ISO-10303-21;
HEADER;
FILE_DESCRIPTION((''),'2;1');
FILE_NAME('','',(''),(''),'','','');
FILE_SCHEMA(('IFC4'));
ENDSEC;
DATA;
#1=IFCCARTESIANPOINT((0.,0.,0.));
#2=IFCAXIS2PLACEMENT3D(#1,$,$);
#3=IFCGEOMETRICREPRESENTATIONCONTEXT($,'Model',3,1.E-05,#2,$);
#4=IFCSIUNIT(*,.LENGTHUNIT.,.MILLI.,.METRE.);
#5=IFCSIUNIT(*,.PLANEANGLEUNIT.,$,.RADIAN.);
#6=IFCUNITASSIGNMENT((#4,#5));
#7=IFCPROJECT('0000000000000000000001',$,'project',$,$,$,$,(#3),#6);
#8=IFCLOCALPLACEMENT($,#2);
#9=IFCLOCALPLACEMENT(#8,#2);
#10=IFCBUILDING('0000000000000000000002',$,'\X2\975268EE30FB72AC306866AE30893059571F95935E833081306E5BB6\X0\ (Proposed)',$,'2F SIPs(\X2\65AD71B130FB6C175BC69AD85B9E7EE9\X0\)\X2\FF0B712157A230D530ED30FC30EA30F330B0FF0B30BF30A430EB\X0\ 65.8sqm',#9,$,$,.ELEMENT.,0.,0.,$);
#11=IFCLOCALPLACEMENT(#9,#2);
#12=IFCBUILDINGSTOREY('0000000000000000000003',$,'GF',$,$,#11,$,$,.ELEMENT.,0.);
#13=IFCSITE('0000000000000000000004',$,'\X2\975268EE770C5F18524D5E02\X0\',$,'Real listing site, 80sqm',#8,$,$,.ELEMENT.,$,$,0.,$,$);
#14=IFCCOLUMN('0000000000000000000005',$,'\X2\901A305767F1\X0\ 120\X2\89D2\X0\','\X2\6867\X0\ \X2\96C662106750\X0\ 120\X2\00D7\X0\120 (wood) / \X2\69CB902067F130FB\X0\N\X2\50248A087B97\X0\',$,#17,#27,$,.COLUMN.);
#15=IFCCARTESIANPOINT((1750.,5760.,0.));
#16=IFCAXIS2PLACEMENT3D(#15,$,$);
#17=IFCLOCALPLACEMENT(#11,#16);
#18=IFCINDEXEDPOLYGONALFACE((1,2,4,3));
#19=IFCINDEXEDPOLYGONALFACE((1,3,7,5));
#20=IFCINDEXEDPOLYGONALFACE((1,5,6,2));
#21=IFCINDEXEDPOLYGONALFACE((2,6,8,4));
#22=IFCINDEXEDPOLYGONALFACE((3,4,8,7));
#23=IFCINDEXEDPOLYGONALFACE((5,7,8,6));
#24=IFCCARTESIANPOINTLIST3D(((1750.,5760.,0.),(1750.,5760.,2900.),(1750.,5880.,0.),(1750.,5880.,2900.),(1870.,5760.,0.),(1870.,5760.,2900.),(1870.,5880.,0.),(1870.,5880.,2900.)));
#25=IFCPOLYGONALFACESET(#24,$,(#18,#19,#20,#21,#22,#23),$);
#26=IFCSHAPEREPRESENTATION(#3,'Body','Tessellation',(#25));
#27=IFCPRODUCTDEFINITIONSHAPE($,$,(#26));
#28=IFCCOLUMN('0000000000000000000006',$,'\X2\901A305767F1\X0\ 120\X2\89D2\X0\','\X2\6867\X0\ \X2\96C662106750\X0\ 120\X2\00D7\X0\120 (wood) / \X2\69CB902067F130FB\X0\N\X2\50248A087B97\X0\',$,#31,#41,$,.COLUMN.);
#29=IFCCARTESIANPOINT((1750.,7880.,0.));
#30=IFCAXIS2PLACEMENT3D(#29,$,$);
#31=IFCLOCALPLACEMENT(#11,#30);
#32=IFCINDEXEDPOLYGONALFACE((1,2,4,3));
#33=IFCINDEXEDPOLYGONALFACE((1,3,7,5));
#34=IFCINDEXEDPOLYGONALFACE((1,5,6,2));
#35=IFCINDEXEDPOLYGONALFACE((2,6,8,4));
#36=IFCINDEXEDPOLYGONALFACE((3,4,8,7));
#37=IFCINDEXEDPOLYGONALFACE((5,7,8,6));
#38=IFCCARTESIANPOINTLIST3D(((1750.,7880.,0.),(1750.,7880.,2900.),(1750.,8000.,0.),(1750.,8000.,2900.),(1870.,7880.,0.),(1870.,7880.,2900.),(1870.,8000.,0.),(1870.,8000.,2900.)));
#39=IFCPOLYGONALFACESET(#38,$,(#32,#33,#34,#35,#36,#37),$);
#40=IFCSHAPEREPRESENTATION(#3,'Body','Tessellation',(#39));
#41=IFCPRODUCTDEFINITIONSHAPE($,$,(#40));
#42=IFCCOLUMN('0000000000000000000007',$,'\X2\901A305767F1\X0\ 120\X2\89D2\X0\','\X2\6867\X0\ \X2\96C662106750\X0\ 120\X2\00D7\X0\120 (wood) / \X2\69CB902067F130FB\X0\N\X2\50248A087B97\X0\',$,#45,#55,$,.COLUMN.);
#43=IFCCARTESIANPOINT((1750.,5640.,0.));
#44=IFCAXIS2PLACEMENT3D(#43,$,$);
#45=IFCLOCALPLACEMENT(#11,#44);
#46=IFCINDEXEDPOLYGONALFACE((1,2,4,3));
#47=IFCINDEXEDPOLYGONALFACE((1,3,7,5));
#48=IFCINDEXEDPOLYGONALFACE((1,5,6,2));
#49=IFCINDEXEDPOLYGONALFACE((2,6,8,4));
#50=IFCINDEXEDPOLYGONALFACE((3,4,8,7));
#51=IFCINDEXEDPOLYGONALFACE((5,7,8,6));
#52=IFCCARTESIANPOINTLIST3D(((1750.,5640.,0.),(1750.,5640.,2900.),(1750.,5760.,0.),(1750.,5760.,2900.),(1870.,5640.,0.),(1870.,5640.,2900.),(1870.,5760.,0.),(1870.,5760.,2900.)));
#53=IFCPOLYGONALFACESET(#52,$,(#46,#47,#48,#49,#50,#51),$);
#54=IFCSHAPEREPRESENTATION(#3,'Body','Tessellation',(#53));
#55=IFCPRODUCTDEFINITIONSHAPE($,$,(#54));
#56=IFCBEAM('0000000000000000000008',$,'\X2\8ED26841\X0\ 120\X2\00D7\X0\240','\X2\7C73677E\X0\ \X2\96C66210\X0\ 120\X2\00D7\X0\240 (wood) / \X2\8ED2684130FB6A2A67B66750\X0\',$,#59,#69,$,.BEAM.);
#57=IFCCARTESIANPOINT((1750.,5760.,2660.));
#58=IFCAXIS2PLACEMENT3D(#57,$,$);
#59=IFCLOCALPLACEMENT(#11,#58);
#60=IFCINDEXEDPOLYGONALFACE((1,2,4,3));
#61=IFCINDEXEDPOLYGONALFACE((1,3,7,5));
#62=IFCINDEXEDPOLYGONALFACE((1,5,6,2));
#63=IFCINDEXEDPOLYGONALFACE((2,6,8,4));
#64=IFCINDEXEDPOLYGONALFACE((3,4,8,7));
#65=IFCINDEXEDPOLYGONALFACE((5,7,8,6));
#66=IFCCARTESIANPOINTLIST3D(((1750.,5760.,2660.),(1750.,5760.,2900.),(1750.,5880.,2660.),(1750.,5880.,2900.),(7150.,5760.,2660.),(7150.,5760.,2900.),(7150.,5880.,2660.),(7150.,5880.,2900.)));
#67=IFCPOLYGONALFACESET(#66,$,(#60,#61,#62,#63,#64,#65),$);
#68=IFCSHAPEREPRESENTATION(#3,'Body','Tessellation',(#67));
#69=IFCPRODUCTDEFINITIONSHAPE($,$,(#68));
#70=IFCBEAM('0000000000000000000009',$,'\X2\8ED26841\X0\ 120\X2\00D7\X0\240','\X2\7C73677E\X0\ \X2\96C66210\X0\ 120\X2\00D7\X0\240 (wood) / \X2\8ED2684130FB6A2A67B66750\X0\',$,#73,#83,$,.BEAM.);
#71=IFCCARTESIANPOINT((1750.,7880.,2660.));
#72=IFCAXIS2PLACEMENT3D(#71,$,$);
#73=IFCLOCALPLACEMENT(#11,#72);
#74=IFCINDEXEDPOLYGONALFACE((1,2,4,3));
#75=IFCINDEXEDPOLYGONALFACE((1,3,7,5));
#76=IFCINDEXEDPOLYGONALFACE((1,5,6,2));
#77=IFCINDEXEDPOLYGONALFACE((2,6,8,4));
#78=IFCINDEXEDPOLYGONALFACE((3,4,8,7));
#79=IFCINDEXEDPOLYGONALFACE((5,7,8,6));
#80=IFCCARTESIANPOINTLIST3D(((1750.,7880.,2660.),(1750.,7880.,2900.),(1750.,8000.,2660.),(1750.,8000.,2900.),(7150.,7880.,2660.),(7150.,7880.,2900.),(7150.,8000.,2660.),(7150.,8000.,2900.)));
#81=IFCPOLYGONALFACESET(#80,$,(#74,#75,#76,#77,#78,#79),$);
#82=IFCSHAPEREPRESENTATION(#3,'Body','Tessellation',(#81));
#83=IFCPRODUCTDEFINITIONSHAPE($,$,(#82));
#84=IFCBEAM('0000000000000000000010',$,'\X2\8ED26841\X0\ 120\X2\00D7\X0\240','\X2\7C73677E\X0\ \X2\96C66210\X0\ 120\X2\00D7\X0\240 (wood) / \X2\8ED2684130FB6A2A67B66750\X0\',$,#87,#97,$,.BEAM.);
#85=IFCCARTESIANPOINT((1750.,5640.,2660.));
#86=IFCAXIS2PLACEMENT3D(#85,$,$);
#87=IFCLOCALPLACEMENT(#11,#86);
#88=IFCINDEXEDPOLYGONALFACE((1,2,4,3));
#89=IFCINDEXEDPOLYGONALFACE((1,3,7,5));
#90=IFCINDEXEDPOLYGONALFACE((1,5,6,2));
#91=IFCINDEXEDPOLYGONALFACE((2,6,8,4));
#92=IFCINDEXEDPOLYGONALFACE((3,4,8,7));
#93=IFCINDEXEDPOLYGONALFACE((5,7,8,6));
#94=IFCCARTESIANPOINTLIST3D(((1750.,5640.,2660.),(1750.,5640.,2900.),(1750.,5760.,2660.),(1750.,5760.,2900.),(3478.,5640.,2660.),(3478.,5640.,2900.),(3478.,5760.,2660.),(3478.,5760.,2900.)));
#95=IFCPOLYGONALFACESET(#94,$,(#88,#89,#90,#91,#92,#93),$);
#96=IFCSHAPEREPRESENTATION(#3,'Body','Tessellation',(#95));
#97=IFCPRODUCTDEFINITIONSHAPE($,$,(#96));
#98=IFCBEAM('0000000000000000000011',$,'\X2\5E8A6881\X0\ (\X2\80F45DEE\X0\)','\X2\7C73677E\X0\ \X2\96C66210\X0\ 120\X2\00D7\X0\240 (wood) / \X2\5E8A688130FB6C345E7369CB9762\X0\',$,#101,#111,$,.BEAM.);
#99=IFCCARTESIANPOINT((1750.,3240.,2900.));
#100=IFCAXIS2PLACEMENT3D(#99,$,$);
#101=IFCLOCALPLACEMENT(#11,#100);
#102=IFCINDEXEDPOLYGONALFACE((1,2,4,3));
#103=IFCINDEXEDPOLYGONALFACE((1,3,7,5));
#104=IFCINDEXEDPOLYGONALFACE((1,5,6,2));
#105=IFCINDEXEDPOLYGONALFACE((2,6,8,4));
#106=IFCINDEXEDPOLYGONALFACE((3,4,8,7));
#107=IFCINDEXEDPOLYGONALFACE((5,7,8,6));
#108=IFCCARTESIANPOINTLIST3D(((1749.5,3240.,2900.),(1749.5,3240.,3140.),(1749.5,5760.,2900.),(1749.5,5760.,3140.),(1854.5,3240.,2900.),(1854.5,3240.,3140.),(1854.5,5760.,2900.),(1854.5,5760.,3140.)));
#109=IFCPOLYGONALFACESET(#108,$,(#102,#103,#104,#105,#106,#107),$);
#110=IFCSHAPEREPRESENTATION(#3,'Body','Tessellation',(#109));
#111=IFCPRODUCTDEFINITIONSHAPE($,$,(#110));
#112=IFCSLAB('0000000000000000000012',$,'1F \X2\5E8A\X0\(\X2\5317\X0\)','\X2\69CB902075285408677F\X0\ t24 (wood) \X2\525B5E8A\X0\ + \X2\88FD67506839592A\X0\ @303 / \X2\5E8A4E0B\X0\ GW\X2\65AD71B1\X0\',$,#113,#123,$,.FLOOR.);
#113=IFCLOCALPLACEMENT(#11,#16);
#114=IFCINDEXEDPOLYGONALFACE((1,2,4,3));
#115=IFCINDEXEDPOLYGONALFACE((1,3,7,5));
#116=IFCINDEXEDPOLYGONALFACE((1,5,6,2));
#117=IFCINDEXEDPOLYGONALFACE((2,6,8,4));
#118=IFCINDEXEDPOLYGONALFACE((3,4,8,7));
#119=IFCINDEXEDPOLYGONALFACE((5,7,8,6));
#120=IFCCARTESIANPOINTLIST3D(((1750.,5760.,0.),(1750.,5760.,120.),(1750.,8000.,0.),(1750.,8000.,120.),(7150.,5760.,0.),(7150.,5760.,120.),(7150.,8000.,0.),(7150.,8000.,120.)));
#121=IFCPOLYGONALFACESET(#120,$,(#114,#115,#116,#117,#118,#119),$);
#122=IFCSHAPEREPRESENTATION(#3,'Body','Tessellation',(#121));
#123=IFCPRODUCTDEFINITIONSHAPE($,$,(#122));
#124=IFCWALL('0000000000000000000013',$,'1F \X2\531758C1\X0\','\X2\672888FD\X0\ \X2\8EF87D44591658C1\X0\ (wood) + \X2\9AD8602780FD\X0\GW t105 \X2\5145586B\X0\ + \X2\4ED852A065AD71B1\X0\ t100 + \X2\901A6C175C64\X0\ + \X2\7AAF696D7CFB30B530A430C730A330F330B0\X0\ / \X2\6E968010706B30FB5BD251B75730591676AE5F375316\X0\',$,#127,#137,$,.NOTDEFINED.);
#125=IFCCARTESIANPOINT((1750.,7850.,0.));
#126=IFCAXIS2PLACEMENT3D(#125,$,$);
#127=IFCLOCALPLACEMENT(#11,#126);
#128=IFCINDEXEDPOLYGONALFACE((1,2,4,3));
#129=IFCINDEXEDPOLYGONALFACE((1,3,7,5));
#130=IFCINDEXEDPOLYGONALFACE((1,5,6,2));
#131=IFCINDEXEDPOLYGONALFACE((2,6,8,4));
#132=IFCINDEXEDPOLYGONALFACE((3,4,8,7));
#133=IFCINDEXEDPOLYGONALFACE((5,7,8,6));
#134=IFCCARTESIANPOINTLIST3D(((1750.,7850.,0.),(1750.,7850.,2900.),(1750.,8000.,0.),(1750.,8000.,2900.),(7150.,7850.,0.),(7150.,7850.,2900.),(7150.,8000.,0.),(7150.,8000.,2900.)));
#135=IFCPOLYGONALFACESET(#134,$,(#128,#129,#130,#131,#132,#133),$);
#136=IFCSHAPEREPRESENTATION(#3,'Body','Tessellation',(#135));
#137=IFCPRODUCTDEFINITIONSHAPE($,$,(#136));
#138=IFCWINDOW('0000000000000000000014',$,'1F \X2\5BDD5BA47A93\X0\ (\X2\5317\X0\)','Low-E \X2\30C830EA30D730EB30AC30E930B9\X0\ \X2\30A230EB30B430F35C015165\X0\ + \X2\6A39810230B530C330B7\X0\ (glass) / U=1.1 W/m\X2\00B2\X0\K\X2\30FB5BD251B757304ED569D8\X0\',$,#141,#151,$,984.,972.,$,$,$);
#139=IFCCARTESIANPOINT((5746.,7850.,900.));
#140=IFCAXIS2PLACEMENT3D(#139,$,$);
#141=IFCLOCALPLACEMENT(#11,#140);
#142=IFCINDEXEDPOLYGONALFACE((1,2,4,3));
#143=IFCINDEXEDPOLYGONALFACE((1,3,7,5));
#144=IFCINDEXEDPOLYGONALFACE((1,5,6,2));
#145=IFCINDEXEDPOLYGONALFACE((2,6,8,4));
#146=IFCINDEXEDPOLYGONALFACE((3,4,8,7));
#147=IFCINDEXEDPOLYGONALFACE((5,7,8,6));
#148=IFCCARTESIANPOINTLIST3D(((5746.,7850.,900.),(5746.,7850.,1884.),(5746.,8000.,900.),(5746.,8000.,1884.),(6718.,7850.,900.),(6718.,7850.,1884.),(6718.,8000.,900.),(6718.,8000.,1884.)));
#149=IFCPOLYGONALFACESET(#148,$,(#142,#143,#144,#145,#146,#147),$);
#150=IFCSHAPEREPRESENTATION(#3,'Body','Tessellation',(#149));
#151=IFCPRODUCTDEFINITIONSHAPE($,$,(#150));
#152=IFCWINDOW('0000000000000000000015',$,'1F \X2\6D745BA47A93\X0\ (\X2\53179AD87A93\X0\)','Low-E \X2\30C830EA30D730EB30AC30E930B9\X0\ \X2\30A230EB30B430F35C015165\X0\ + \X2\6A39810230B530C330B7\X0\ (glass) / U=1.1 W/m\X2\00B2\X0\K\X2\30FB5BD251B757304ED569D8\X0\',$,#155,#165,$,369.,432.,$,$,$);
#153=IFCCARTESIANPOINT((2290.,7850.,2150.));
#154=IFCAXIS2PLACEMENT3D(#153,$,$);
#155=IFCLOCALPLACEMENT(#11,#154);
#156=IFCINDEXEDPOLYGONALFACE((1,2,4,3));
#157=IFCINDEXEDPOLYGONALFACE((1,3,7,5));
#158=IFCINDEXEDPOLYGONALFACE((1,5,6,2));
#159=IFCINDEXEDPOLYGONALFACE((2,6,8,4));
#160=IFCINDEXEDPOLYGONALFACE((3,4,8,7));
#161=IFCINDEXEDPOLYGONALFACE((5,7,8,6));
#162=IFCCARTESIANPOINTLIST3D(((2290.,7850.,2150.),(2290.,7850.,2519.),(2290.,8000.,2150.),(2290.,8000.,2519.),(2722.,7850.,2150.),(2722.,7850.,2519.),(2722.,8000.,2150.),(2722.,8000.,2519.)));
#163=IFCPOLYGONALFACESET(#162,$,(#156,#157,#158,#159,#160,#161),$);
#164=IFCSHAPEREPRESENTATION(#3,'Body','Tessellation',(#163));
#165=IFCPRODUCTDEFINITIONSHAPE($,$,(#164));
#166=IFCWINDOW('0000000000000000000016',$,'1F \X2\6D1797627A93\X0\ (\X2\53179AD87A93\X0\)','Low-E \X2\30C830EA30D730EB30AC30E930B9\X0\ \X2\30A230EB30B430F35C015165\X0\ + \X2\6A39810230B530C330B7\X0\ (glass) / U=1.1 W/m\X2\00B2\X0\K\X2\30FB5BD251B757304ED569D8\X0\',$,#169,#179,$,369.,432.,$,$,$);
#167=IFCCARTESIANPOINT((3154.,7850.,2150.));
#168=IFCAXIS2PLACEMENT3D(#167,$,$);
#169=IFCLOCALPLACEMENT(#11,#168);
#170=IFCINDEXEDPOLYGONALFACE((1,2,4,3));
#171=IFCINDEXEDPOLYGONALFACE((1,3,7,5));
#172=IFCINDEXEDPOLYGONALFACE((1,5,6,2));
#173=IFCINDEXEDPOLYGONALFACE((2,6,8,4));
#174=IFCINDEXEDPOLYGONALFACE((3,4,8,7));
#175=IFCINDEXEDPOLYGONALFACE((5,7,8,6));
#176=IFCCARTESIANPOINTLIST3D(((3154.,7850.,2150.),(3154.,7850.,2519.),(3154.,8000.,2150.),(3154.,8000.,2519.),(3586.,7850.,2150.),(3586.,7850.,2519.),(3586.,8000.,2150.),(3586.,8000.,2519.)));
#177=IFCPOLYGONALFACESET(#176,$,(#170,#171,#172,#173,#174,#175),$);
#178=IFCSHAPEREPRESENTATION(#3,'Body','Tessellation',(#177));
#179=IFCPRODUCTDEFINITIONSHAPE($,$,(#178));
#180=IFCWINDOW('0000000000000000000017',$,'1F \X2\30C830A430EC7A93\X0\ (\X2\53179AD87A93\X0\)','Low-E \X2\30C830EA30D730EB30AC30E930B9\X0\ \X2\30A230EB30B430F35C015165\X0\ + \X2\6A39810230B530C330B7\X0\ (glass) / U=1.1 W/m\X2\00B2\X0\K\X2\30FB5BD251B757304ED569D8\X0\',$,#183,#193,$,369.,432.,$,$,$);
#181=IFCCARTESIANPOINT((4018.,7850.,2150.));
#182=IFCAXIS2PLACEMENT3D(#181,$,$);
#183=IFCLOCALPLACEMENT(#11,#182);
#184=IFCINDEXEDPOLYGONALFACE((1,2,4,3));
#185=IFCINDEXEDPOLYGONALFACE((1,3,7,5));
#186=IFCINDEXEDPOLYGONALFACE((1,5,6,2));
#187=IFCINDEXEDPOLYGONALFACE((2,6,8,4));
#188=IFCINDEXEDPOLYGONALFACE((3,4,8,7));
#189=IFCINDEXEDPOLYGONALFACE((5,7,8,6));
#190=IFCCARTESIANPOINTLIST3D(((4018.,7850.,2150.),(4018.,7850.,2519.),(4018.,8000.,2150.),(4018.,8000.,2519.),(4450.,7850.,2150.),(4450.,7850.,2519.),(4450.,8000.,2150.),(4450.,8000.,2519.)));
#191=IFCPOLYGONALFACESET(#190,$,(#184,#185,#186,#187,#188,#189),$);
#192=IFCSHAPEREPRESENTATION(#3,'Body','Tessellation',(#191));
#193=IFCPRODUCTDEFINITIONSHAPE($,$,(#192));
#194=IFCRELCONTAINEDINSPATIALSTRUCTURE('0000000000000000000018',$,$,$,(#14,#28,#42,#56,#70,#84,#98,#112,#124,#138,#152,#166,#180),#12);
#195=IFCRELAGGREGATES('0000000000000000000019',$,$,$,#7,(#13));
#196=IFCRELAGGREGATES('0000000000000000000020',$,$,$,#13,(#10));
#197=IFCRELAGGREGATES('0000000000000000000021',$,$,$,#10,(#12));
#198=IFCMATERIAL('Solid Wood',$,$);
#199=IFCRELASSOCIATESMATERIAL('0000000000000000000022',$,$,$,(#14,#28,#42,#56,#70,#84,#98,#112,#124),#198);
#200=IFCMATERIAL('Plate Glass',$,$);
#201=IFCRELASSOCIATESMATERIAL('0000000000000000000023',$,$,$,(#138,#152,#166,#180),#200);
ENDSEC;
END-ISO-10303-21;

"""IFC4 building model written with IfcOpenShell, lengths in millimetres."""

from ifc_helpers import new_model, si_unit, frame, frame_2d, origin, place, context, project, spatial, rectangle, extrude, material, element, fill, save


model = new_model("IFC4")

# Units and contexts
model_context = context("Model", 3, precision=1e-05, world=origin())
ifc_project = project(units=[si_unit("LENGTHUNIT", "METRE", prefix="MILLI"), si_unit("PLANEANGLEUNIT", "RADIAN")], contexts=[model_context])

# Site, building, storey
site_placement = place(None, origin())
site = spatial("IfcSite", under=ifc_project, at=site_placement, Name="青森県弘前市", ObjectType="Real listing site, 80sqm", CompositionType="ELEMENT", RefElevation=0.0)
building_placement = place(site_placement, origin())
building = spatial("IfcBuilding", under=site, at=building_placement, Name="青森・犬と暮らす土間広めの家 (Proposed)", ObjectType="2F SIPs(断熱・気密高实绩)＋無垢フローリング＋タイル 65.8sqm", CompositionType="ELEMENT", ElevationOfRefHeight=0.0, ElevationOfTerrain=0.0)
storey_placement = place(building_placement, origin())
storey = spatial("IfcBuildingStorey", under=building, at=storey_placement, Name="GF", CompositionType="ELEMENT", Elevation=0.0)

# Columns
ifc_material_1 = material(Name="Solid Wood")
column_1_placement = place(storey_placement, frame((1750.0, 5760.0, 0.0)))
element("IfcColumn", 1, at=column_1_placement, inside=storey, material=ifc_material_1, Name="通し柱 120角", Description="桧 集成材 120×120 (wood) / 構造柱・N値計算", PredefinedType="COLUMN", context=model_context, shape_type="SweptSolid", body=[
    extrude(rectangle(XDim=120.0, YDim=120.0, at=frame_2d((60.0, 60.0))), frame((1750.0, 5760.0, 0.0)), (0.0, 0.0, 1.0), 2900.0),
])
column_2_placement = place(storey_placement, frame((1750.0, 7880.0, 0.0)))
element("IfcColumn", 2, at=column_2_placement, inside=storey, material=ifc_material_1, Name="通し柱 120角", Description="桧 集成材 120×120 (wood) / 構造柱・N値計算", PredefinedType="COLUMN", context=model_context, shape_type="SweptSolid", body=[
    extrude(rectangle(XDim=120.0, YDim=120.0, at=frame_2d((60.0, 60.0))), frame((1750.0, 7880.0, 0.0)), (0.0, 0.0, 1.0), 2900.0),
])
column_3_placement = place(storey_placement, frame((1750.0, 5640.0, 0.0)))
element("IfcColumn", 3, at=column_3_placement, inside=storey, material=ifc_material_1, Name="通し柱 120角", Description="桧 集成材 120×120 (wood) / 構造柱・N値計算", PredefinedType="COLUMN", context=model_context, shape_type="SweptSolid", body=[
    extrude(rectangle(XDim=120.0, YDim=120.0, at=frame_2d((60.0, 60.0))), frame((1750.0, 5640.0, 0.0)), (0.0, 0.0, 1.0), 2900.0),
])

# Beams
beam_1_placement = place(storey_placement, frame((1750.0, 5760.0, 2660.0)))
element("IfcBeam", 4, at=beam_1_placement, inside=storey, material=ifc_material_1, Name="軒桁 120×240", Description="米松 集成 120×240 (wood) / 軒桁・横架材", PredefinedType="BEAM", context=model_context, shape_type="SweptSolid", body=[
    extrude(rectangle(XDim=5400.0, YDim=120.0, at=frame_2d((2700.0, 60.0))), frame((1750.0, 5760.0, 2660.0)), (0.0, 0.0, 1.0), 240.0),
])
beam_2_placement = place(storey_placement, frame((1750.0, 7880.0, 2660.0)))
element("IfcBeam", 5, at=beam_2_placement, inside=storey, material=ifc_material_1, Name="軒桁 120×240", Description="米松 集成 120×240 (wood) / 軒桁・横架材", PredefinedType="BEAM", context=model_context, shape_type="SweptSolid", body=[
    extrude(rectangle(XDim=5400.0, YDim=120.0, at=frame_2d((2700.0, 60.0))), frame((1750.0, 7880.0, 2660.0)), (0.0, 0.0, 1.0), 240.0),
])
beam_3_placement = place(storey_placement, frame((1750.0, 5640.0, 2660.0)))
element("IfcBeam", 6, at=beam_3_placement, inside=storey, material=ifc_material_1, Name="軒桁 120×240", Description="米松 集成 120×240 (wood) / 軒桁・横架材", PredefinedType="BEAM", context=model_context, shape_type="SweptSolid", body=[
    extrude(rectangle(XDim=1728.0, YDim=120.0, at=frame_2d((864.0, 60.0))), frame((1750.0, 5640.0, 2660.0)), (0.0, 0.0, 1.0), 240.0),
])
beam_4_placement = place(storey_placement, frame((1750.0, 3240.0, 2900.0)))
element("IfcBeam", 7, at=beam_4_placement, inside=storey, material=ifc_material_1, Name="床梁 (胴差)", Description="米松 集成 120×240 (wood) / 床梁・水平構面", PredefinedType="BEAM", context=model_context, shape_type="SweptSolid", body=[
    extrude(rectangle(XDim=105.0, YDim=2520.0, at=frame_2d((52.0, 1260.0))), frame((1750.0, 3240.0, 2900.0)), (0.0, 0.0, 1.0), 240.0),
])

# Slab
slab_placement = place(storey_placement, frame((1750.0, 5760.0, 0.0)))
element("IfcSlab", 8, at=slab_placement, inside=storey, material=ifc_material_1, Name="1F 床(北)", Description="構造用合板 t24 (wood) 剛床 + 製材根太 @303 / 床下 GW断熱", PredefinedType="FLOOR", context=model_context, shape_type="SweptSolid", body=[
    extrude(rectangle(XDim=5400.0, YDim=2240.0, at=frame_2d((2700.0, 1120.0))), frame((1750.0, 5760.0, 0.0)), (0.0, 0.0, 1.0), 120.0),
])

# Wall, openings, windows
wall_1_placement = place(storey_placement, frame((1750.0, 7850.0, 0.0)))
wall_1 = element("IfcWall", 9, at=wall_1_placement, inside=storey, material=ifc_material_1, Name="1F 北壁", Description="木製 軸組外壁 (wood) + 高性能GW t105 充填 + 付加断熱 t100 + 通気層 + 窯業系サイディング / 準耐火・寒冷地外皮強化", PredefinedType="NOTDEFINED", context=model_context, shape_type="SweptSolid", body=[
    extrude(rectangle(XDim=5400.0, YDim=150.0, at=frame_2d((2700.0, 75.0))), frame((1750.0, 7850.0, 0.0)), (0.0, 0.0, 1.0), 2900.0),
])
opening_1_placement = place(storey_placement, frame((5746.0, 7850.0, 900.0)))
opening_1 = element("IfcOpeningElement", 10, at=opening_1_placement, cuts=wall_1, PredefinedType="NOTDEFINED", context=model_context, shape_type="SweptSolid", body=[
    extrude(rectangle(XDim=972.0, YDim=150.0, at=frame_2d((486.0, 75.0))), frame((5746.0, 7850.0, 900.0)), (0.0, 0.0, 1.0), 984.0),
])
opening_2_placement = place(storey_placement, frame((2290.0, 7850.0, 2150.0)))
opening_2 = element("IfcOpeningElement", 11, at=opening_2_placement, cuts=wall_1, PredefinedType="NOTDEFINED", context=model_context, shape_type="SweptSolid", body=[
    extrude(rectangle(XDim=432.0, YDim=150.0, at=frame_2d((216.0, 75.0))), frame((2290.0, 7850.0, 2150.0)), (0.0, 0.0, 1.0), 369.0),
])
opening_3_placement = place(storey_placement, frame((3154.0, 7850.0, 2150.0)))
opening_3 = element("IfcOpeningElement", 12, at=opening_3_placement, cuts=wall_1, PredefinedType="NOTDEFINED", context=model_context, shape_type="SweptSolid", body=[
    extrude(rectangle(XDim=432.0, YDim=150.0, at=frame_2d((216.0, 75.0))), frame((3154.0, 7850.0, 2150.0)), (0.0, 0.0, 1.0), 369.0),
])
opening_4_placement = place(storey_placement, frame((4018.0, 7850.0, 2150.0)))
opening_4 = element("IfcOpeningElement", 13, at=opening_4_placement, cuts=wall_1, PredefinedType="NOTDEFINED", context=model_context, shape_type="SweptSolid", body=[
    extrude(rectangle(XDim=432.0, YDim=150.0, at=frame_2d((216.0, 75.0))), frame((4018.0, 7850.0, 2150.0)), (0.0, 0.0, 1.0), 369.0),
])
ifc_material_2 = material(Name="Plate Glass")
window_1_placement = place(storey_placement, frame((5746.0, 7850.0, 900.0)))
window_1 = element("IfcWindow", 14, at=window_1_placement, inside=storey, material=ifc_material_2, Name="1F 寝室窓 (北)", Description="Low-E トリプルガラス アルゴン封入 + 樹脂サッシ (glass) / U=1.1 W/m²K・寒冷地仕様", OverallHeight=984.0, OverallWidth=972.0, context=model_context, shape_type="SweptSolid", body=[
    extrude(rectangle(XDim=972.0, YDim=150.0, at=frame_2d((486.0, 75.0))), frame((5746.0, 7850.0, 900.0)), (0.0, 0.0, 1.0), 984.0),
])
fill(opening_1, window_1)
window_2_placement = place(storey_placement, frame((2290.0, 7850.0, 2150.0)))
window_2 = element("IfcWindow", 15, at=window_2_placement, inside=storey, material=ifc_material_2, Name="1F 浴室窓 (北高窓)", Description="Low-E トリプルガラス アルゴン封入 + 樹脂サッシ (glass) / U=1.1 W/m²K・寒冷地仕様", OverallHeight=369.0, OverallWidth=432.0, context=model_context, shape_type="SweptSolid", body=[
    extrude(rectangle(XDim=432.0, YDim=150.0, at=frame_2d((216.0, 75.0))), frame((2290.0, 7850.0, 2150.0)), (0.0, 0.0, 1.0), 369.0),
])
fill(opening_2, window_2)
window_3_placement = place(storey_placement, frame((3154.0, 7850.0, 2150.0)))
window_3 = element("IfcWindow", 16, at=window_3_placement, inside=storey, material=ifc_material_2, Name="1F 洗面窓 (北高窓)", Description="Low-E トリプルガラス アルゴン封入 + 樹脂サッシ (glass) / U=1.1 W/m²K・寒冷地仕様", OverallHeight=369.0, OverallWidth=432.0, context=model_context, shape_type="SweptSolid", body=[
    extrude(rectangle(XDim=432.0, YDim=150.0, at=frame_2d((216.0, 75.0))), frame((3154.0, 7850.0, 2150.0)), (0.0, 0.0, 1.0), 369.0),
])
fill(opening_3, window_3)
window_4_placement = place(storey_placement, frame((4018.0, 7850.0, 2150.0)))
window_4 = element("IfcWindow", 17, at=window_4_placement, inside=storey, material=ifc_material_2, Name="1F トイレ窓 (北高窓)", Description="Low-E トリプルガラス アルゴン封入 + 樹脂サッシ (glass) / U=1.1 W/m²K・寒冷地仕様", OverallHeight=369.0, OverallWidth=432.0, context=model_context, shape_type="SweptSolid", body=[
    extrude(rectangle(XDim=432.0, YDim=150.0, at=frame_2d((216.0, 75.0))), frame((4018.0, 7850.0, 2150.0)), (0.0, 0.0, 1.0), 369.0),
])
fill(opening_4, window_4)

save(model, "model.ifc")
